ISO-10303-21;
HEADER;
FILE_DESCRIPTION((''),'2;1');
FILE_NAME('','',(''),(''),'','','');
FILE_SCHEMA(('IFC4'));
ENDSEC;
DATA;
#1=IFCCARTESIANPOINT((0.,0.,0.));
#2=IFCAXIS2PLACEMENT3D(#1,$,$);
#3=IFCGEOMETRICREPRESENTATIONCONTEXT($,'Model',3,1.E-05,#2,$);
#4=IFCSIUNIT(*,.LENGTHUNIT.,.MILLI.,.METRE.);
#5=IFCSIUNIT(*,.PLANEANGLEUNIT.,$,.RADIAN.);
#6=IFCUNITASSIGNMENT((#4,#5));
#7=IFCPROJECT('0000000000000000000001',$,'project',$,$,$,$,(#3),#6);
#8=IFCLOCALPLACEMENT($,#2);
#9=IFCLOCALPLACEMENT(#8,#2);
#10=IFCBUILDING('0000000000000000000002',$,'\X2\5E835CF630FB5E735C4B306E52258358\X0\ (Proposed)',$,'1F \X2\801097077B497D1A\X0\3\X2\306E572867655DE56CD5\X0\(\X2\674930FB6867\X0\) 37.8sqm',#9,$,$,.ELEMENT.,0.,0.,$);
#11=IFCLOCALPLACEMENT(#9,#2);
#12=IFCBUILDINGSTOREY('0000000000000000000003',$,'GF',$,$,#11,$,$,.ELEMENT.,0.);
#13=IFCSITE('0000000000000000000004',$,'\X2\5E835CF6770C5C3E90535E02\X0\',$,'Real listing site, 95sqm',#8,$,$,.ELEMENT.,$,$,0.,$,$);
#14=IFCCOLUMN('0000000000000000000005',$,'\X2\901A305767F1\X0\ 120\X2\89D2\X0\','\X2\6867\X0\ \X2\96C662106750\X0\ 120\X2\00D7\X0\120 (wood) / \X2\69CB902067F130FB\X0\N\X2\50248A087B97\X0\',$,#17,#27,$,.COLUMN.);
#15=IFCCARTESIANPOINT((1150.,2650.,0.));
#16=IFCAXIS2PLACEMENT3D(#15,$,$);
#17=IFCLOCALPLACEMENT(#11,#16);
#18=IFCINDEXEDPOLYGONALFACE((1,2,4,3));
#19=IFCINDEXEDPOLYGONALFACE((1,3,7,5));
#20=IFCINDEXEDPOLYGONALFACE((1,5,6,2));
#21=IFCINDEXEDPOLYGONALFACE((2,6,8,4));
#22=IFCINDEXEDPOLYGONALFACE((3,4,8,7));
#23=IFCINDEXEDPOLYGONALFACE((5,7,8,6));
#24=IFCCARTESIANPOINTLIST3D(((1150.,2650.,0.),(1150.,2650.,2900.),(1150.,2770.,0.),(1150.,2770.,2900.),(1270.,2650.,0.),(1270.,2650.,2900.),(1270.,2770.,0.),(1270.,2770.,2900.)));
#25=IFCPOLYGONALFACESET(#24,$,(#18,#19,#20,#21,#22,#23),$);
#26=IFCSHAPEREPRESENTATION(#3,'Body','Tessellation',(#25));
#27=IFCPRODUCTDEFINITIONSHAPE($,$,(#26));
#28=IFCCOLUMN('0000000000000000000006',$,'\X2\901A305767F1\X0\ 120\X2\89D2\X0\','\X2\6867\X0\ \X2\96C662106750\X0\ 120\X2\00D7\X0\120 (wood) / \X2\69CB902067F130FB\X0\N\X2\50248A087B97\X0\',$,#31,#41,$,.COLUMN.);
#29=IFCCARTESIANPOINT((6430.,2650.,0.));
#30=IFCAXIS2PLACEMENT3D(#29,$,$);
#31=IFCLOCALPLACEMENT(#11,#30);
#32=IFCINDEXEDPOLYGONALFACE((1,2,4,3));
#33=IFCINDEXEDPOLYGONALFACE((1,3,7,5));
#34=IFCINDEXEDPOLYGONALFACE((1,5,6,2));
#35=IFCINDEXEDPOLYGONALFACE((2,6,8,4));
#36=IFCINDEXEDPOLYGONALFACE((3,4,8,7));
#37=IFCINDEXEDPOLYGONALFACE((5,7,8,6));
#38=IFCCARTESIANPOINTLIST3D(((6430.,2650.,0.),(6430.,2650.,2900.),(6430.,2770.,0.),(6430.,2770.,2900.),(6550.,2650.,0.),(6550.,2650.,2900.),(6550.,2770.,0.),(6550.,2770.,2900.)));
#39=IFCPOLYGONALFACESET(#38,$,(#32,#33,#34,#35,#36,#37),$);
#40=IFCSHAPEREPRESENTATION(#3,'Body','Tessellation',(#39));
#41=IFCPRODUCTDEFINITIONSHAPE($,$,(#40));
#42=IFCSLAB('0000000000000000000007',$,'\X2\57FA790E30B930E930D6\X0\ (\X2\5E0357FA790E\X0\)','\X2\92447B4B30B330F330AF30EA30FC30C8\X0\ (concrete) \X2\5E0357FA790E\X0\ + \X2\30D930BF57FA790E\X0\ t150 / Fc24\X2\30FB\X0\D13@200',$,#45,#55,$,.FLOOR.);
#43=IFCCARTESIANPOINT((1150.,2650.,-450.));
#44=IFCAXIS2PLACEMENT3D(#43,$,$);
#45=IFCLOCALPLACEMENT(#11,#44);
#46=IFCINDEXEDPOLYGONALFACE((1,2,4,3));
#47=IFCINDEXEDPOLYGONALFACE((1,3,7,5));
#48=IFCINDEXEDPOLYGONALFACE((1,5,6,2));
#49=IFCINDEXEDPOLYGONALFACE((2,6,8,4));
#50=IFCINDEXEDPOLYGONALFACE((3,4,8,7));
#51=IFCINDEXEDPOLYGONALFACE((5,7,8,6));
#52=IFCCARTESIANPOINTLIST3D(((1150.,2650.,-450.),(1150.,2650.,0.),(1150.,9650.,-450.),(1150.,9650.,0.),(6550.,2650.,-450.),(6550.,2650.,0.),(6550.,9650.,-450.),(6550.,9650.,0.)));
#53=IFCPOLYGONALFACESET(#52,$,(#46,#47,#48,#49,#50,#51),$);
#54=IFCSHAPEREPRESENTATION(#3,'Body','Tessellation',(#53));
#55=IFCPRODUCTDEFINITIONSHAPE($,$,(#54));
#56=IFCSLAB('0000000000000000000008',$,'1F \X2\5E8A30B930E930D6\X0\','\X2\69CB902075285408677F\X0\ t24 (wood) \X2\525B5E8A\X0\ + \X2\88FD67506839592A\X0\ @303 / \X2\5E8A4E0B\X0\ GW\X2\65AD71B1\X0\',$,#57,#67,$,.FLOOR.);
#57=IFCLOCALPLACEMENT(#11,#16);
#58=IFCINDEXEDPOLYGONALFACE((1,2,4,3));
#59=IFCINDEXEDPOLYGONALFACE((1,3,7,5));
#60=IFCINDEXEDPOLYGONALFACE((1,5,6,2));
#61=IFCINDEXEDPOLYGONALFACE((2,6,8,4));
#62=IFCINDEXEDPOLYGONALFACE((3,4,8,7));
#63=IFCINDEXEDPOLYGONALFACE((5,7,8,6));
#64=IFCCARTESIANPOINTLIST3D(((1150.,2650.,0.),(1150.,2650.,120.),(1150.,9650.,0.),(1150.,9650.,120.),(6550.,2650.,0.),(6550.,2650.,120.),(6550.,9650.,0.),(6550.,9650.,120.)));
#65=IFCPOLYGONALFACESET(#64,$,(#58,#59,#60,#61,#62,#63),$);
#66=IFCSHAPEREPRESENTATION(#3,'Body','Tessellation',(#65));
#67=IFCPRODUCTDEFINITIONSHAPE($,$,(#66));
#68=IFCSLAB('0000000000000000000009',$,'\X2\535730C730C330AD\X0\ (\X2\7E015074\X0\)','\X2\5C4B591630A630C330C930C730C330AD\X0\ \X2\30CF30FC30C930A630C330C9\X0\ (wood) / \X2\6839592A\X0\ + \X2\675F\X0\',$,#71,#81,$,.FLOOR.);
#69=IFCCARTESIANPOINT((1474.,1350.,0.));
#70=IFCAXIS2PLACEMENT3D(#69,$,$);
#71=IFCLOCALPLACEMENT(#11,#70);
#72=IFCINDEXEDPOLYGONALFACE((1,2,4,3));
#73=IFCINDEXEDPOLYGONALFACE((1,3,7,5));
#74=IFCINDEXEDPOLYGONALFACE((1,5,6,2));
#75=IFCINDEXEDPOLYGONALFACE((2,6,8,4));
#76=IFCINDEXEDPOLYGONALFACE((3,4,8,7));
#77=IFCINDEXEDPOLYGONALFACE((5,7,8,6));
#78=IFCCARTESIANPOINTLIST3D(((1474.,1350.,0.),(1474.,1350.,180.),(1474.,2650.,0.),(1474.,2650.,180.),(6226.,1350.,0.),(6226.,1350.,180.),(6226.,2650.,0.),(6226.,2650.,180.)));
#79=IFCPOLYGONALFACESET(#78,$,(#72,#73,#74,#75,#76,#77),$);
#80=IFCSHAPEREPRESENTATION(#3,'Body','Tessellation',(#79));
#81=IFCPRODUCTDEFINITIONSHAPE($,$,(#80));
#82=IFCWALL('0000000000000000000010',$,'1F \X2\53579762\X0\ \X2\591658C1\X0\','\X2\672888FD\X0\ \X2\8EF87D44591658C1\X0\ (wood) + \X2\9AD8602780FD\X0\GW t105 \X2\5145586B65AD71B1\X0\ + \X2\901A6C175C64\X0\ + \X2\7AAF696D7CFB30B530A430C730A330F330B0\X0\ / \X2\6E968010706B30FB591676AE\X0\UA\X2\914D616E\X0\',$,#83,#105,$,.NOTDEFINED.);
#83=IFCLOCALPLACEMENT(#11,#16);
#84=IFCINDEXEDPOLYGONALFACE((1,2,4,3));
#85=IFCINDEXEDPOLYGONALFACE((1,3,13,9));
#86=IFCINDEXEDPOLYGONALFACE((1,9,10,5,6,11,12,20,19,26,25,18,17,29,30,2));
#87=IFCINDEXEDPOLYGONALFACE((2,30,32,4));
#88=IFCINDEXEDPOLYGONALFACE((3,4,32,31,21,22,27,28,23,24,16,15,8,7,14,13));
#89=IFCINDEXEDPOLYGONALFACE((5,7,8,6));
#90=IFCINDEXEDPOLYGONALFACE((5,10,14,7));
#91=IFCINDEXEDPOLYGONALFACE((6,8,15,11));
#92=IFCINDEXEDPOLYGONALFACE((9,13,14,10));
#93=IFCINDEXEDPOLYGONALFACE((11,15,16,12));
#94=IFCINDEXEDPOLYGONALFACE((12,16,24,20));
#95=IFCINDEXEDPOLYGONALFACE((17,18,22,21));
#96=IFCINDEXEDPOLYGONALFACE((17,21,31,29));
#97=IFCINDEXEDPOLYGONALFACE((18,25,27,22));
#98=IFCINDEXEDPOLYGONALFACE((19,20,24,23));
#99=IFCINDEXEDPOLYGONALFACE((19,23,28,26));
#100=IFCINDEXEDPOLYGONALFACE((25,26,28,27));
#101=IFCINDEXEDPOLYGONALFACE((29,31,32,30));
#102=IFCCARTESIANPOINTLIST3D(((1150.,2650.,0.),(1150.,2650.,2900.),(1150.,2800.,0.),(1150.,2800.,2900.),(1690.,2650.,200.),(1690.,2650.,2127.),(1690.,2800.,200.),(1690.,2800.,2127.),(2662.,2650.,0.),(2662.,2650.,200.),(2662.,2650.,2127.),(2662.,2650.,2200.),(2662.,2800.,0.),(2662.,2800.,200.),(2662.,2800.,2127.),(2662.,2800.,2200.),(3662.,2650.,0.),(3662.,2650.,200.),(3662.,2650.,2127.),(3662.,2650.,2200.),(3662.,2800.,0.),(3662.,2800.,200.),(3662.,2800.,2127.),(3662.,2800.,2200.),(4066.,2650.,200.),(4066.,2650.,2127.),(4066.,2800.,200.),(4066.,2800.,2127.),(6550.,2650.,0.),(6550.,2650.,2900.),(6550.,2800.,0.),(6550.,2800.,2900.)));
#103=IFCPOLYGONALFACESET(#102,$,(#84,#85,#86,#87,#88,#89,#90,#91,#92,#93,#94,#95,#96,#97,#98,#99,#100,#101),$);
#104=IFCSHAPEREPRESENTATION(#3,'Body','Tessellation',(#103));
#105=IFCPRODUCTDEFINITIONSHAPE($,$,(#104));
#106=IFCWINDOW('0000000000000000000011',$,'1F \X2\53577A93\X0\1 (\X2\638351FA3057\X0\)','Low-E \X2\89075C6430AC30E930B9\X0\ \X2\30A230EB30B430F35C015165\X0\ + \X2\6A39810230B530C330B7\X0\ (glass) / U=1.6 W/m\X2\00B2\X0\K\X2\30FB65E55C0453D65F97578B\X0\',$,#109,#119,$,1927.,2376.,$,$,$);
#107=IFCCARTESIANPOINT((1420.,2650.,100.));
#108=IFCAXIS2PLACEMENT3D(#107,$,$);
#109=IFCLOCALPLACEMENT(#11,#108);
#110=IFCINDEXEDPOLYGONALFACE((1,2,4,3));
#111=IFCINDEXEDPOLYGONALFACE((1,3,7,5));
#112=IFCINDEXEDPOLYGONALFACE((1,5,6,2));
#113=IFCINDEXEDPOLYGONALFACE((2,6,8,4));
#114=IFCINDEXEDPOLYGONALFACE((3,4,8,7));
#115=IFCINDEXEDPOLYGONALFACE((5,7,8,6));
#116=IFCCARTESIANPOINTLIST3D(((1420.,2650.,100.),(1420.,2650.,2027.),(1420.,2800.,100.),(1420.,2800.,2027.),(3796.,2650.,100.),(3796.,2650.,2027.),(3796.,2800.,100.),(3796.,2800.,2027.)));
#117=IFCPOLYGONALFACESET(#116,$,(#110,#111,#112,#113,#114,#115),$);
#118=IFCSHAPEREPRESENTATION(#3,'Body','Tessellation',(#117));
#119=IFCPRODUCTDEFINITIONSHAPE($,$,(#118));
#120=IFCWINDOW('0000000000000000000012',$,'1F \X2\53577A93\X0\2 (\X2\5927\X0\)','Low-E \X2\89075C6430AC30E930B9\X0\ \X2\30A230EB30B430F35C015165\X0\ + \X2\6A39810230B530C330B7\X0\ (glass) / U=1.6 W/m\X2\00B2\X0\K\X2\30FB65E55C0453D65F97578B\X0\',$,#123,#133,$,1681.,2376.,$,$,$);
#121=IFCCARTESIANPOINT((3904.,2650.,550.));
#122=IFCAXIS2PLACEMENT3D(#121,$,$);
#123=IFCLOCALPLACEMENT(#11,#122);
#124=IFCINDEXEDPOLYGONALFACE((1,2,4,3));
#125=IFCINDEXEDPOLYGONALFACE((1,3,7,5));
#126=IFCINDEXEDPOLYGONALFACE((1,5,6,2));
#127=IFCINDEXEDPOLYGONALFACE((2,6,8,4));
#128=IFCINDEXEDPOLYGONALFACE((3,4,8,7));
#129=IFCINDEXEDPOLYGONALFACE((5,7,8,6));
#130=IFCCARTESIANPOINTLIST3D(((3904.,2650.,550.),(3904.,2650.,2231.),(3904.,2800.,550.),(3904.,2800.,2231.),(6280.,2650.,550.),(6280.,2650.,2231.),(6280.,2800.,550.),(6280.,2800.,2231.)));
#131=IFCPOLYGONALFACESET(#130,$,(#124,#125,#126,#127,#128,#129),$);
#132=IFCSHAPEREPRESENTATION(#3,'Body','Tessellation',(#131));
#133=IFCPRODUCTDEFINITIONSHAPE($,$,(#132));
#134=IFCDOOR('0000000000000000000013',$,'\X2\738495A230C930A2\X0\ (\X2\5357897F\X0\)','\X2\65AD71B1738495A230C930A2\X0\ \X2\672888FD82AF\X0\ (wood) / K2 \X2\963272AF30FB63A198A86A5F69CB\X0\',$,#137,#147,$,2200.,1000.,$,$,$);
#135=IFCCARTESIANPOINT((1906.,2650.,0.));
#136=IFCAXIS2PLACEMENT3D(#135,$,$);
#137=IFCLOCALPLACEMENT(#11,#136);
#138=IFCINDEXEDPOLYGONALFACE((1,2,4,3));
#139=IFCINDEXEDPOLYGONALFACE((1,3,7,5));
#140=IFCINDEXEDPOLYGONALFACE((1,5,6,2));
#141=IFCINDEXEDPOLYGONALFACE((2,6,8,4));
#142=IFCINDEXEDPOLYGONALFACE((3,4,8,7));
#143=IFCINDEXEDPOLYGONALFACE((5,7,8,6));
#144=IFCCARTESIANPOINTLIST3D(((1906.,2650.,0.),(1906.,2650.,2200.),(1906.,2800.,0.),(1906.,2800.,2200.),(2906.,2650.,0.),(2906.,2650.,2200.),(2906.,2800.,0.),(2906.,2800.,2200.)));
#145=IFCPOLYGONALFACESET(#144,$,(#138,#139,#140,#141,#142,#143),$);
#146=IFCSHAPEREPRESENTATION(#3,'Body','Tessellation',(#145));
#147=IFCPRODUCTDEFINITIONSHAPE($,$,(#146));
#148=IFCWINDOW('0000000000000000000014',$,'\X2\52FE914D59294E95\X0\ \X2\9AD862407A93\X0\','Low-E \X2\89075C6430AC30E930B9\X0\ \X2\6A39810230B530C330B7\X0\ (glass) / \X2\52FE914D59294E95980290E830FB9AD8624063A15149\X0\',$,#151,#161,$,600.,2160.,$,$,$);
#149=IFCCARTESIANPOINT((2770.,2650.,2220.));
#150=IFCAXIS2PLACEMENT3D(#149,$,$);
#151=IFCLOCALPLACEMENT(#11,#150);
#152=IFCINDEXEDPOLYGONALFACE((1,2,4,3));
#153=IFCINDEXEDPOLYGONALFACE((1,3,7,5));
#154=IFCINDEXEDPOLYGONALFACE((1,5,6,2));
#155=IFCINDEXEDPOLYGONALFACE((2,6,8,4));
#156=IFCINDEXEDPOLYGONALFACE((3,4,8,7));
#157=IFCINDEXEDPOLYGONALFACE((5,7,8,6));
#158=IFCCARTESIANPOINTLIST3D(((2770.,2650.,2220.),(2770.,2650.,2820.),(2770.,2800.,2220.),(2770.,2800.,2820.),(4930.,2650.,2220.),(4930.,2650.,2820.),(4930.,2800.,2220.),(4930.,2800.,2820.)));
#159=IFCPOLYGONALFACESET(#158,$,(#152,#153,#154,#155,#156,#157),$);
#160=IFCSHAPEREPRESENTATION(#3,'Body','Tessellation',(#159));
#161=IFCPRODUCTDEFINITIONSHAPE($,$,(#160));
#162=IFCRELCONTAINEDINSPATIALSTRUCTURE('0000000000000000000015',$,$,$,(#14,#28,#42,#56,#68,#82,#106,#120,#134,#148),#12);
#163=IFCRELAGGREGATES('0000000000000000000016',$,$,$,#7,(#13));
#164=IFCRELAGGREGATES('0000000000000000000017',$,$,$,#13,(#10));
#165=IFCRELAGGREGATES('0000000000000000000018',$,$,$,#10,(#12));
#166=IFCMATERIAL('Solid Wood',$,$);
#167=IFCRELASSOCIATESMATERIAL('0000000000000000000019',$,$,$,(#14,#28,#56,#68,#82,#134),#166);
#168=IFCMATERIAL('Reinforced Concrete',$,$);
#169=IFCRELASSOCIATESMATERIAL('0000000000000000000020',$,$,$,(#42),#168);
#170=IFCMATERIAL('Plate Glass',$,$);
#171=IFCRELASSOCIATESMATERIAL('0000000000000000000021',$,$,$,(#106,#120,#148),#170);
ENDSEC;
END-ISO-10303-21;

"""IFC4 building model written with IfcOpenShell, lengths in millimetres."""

from ifc_helpers import new_model, si_unit, frame, frame_2d, origin, place, context, project, spatial, rectangle, extrude, material, element, fill, save


model = new_model("IFC4")

# Units and contexts
model_context = context("Model", 3, precision=1e-05, world=origin())
ifc_project = project(units=[si_unit("LENGTHUNIT", "METRE", prefix="MILLI"), si_unit("PLANEANGLEUNIT", "RADIAN")], contexts=[model_context])

# Site, building, storey
site_placement = place(None, origin())
site = spatial("IfcSite", under=ifc_project, at=site_placement, Name="広島県尾道市", ObjectType="Real listing site, 95sqm", CompositionType="ELEMENT", RefElevation=0.0)
building_placement = place(site_placement, origin())
building = spatial("IfcBuilding", under=site, at=building_placement, Name="広島・平屋の別荘 (Proposed)", ObjectType="1F 耐震等級3の在来工法(杉・桧) 37.8sqm", CompositionType="ELEMENT", ElevationOfRefHeight=0.0, ElevationOfTerrain=0.0)
storey_placement = place(building_placement, origin())
storey = spatial("IfcBuildingStorey", under=building, at=storey_placement, Name="GF", CompositionType="ELEMENT", Elevation=0.0)

# Columns
ifc_material_1 = material(Name="Solid Wood")
column_1_placement = place(storey_placement, frame((1150.0, 2650.0, 0.0)))
element("IfcColumn", 1, at=column_1_placement, inside=storey, material=ifc_material_1, Name="通し柱 120角", Description="桧 集成材 120×120 (wood) / 構造柱・N値計算", PredefinedType="COLUMN", context=model_context, shape_type="SweptSolid", body=[
    extrude(rectangle(XDim=120.0, YDim=120.0, at=frame_2d((60.0, 60.0))), frame((1150.0, 2650.0, 0.0)), (0.0, 0.0, 1.0), 2900.0),
])
column_2_placement = place(storey_placement, frame((6430.0, 2650.0, 0.0)))
element("IfcColumn", 2, at=column_2_placement, inside=storey, material=ifc_material_1, Name="通し柱 120角", Description="桧 集成材 120×120 (wood) / 構造柱・N値計算", PredefinedType="COLUMN", context=model_context, shape_type="SweptSolid", body=[
    extrude(rectangle(XDim=120.0, YDim=120.0, at=frame_2d((60.0, 60.0))), frame((6430.0, 2650.0, 0.0)), (0.0, 0.0, 1.0), 2900.0),
])

# Slabs
ifc_material_2 = material(Name="Reinforced Concrete")
slab_1_placement = place(storey_placement, frame((1150.0, 2650.0, -450.0)))
element("IfcSlab", 3, at=slab_1_placement, inside=storey, material=ifc_material_2, Name="基礎スラブ (布基礎)", Description="鉄筋コンクリート (concrete) 布基礎 + ベタ基礎 t150 / Fc24・D13@200", PredefinedType="FLOOR", context=model_context, shape_type="SweptSolid", body=[
    extrude(rectangle(XDim=5400.0, YDim=7000.0, at=frame_2d((2700.0, 3500.0))), frame((1150.0, 2650.0, -450.0)), (0.0, 0.0, 1.0), 450.0),
])
slab_2_placement = place(storey_placement, frame((1150.0, 2650.0, 0.0)))
element("IfcSlab", 4, at=slab_2_placement, inside=storey, material=ifc_material_1, Name="1F 床スラブ", Description="構造用合板 t24 (wood) 剛床 + 製材根太 @303 / 床下 GW断熱", PredefinedType="FLOOR", context=model_context, shape_type="SweptSolid", body=[
    extrude(rectangle(XDim=5400.0, YDim=7000.0, at=frame_2d((2700.0, 3500.0))), frame((1150.0, 2650.0, 0.0)), (0.0, 0.0, 1.0), 120.0),
])
slab_3_placement = place(storey_placement, frame((1474.0, 1350.0, 0.0)))
element("IfcSlab", 5, at=slab_3_placement, inside=storey, material=ifc_material_1, Name="南デッキ (縁側)", Description="屋外ウッドデッキ ハードウッド (wood) / 根太 + 束", PredefinedType="FLOOR", context=model_context, shape_type="SweptSolid", body=[
    extrude(rectangle(XDim=4752.0, YDim=1300.0, at=frame_2d((2376.0, 650.0))), frame((1474.0, 1350.0, 0.0)), (0.0, 0.0, 1.0), 180.0),
])

# Wall, openings, windows, door
wall_1_placement = place(storey_placement, frame((1150.0, 2650.0, 0.0)))
wall_1 = element("IfcWall", 6, at=wall_1_placement, inside=storey, material=ifc_material_1, Name="1F 南面 外壁", Description="木製 軸組外壁 (wood) + 高性能GW t105 充填断熱 + 通気層 + 窯業系サイディング / 準耐火・外皮UA配慮", PredefinedType="NOTDEFINED", context=model_context, shape_type="SweptSolid", body=[
    extrude(rectangle(XDim=5400.0, YDim=150.0, at=frame_2d((2700.0, 75.0))), frame((1150.0, 2650.0, 0.0)), (0.0, 0.0, 1.0), 2900.0),
])
opening_1_placement = place(storey_placement, frame((1420.0, 2650.0, 100.0)))
opening_1 = element("IfcOpeningElement", 7, at=opening_1_placement, cuts=wall_1, PredefinedType="NOTDEFINED", context=model_context, shape_type="SweptSolid", body=[
    extrude(rectangle(XDim=2376.0, YDim=150.0, at=frame_2d((1188.0, 75.0))), frame((1420.0, 2650.0, 100.0)), (0.0, 0.0, 1.0), 1927.0),
])
opening_2_placement = place(storey_placement, frame((3904.0, 2650.0, 550.0)))
opening_2 = element("IfcOpeningElement", 8, at=opening_2_placement, cuts=wall_1, PredefinedType="NOTDEFINED", context=model_context, shape_type="SweptSolid", body=[
    extrude(rectangle(XDim=2376.0, YDim=150.0, at=frame_2d((1188.0, 75.0))), frame((3904.0, 2650.0, 550.0)), (0.0, 0.0, 1.0), 1681.0),
])
opening_3_placement = place(storey_placement, frame((1906.0, 2650.0, 0.0)))
opening_3 = element("IfcOpeningElement", 9, at=opening_3_placement, cuts=wall_1, PredefinedType="NOTDEFINED", context=model_context, shape_type="SweptSolid", body=[
    extrude(rectangle(XDim=1000.0, YDim=150.0, at=frame_2d((500.0, 75.0))), frame((1906.0, 2650.0, 0.0)), (0.0, 0.0, 1.0), 2200.0),
])
opening_4_placement = place(storey_placement, frame((2770.0, 2650.0, 2220.0)))
opening_4 = element("IfcOpeningElement", 10, at=opening_4_placement, cuts=wall_1, PredefinedType="NOTDEFINED", context=model_context, shape_type="SweptSolid", body=[
    extrude(rectangle(XDim=2160.0, YDim=150.0, at=frame_2d((1080.0, 75.0))), frame((2770.0, 2650.0, 2220.0)), (0.0, 0.0, 1.0), 600.0),
])
ifc_material_3 = material(Name="Plate Glass")
window_1_placement = place(storey_placement, frame((1420.0, 2650.0, 100.0)))
window_1 = element("IfcWindow", 11, at=window_1_placement, inside=storey, material=ifc_material_3, Name="1F 南窓1 (掃出し)", Description="Low-E 複層ガラス アルゴン封入 + 樹脂サッシ (glass) / U=1.6 W/m²K・日射取得型", OverallHeight=1927.0, OverallWidth=2376.0, context=model_context, shape_type="SweptSolid", body=[
    extrude(rectangle(XDim=2376.0, YDim=150.0, at=frame_2d((1188.0, 75.0))), frame((1420.0, 2650.0, 100.0)), (0.0, 0.0, 1.0), 1927.0),
])
fill(opening_1, window_1)
window_2_placement = place(storey_placement, frame((3904.0, 2650.0, 550.0)))
window_2 = element("IfcWindow", 12, at=window_2_placement, inside=storey, material=ifc_material_3, Name="1F 南窓2 (大)", Description="Low-E 複層ガラス アルゴン封入 + 樹脂サッシ (glass) / U=1.6 W/m²K・日射取得型", OverallHeight=1681.0, OverallWidth=2376.0, context=model_context, shape_type="SweptSolid", body=[
    extrude(rectangle(XDim=2376.0, YDim=150.0, at=frame_2d((1188.0, 75.0))), frame((3904.0, 2650.0, 550.0)), (0.0, 0.0, 1.0), 1681.0),
])
fill(opening_2, window_2)
door_placement = place(storey_placement, frame((1906.0, 2650.0, 0.0)))
door = element("IfcDoor", 13, at=door_placement, inside=storey, material=ifc_material_1, Name="玄関ドア (南西)", Description="断熱玄関ドア 木製芯 (wood) / K2 防犯・採風機構", OverallHeight=2200.0, OverallWidth=1000.0, context=model_context, shape_type="SweptSolid", body=[
    extrude(rectangle(XDim=1000.0, YDim=150.0, at=frame_2d((500.0, 75.0))), frame((1906.0, 2650.0, 0.0)), (0.0, 0.0, 1.0), 2200.0),
])
fill(opening_3, door)
window_3_placement = place(storey_placement, frame((2770.0, 2650.0, 2220.0)))
window_3 = element("IfcWindow", 14, at=window_3_placement, inside=storey, material=ifc_material_3, Name="勾配天井 高所窓", Description="Low-E 複層ガラス 樹脂サッシ (glass) / 勾配天井頂部・高所採光", OverallHeight=600.0, OverallWidth=2160.0, context=model_context, shape_type="SweptSolid", body=[
    extrude(rectangle(XDim=2160.0, YDim=150.0, at=frame_2d((1080.0, 75.0))), frame((2770.0, 2650.0, 2220.0)), (0.0, 0.0, 1.0), 600.0),
])
fill(opening_4, window_3)

save(model, "model.ifc")
